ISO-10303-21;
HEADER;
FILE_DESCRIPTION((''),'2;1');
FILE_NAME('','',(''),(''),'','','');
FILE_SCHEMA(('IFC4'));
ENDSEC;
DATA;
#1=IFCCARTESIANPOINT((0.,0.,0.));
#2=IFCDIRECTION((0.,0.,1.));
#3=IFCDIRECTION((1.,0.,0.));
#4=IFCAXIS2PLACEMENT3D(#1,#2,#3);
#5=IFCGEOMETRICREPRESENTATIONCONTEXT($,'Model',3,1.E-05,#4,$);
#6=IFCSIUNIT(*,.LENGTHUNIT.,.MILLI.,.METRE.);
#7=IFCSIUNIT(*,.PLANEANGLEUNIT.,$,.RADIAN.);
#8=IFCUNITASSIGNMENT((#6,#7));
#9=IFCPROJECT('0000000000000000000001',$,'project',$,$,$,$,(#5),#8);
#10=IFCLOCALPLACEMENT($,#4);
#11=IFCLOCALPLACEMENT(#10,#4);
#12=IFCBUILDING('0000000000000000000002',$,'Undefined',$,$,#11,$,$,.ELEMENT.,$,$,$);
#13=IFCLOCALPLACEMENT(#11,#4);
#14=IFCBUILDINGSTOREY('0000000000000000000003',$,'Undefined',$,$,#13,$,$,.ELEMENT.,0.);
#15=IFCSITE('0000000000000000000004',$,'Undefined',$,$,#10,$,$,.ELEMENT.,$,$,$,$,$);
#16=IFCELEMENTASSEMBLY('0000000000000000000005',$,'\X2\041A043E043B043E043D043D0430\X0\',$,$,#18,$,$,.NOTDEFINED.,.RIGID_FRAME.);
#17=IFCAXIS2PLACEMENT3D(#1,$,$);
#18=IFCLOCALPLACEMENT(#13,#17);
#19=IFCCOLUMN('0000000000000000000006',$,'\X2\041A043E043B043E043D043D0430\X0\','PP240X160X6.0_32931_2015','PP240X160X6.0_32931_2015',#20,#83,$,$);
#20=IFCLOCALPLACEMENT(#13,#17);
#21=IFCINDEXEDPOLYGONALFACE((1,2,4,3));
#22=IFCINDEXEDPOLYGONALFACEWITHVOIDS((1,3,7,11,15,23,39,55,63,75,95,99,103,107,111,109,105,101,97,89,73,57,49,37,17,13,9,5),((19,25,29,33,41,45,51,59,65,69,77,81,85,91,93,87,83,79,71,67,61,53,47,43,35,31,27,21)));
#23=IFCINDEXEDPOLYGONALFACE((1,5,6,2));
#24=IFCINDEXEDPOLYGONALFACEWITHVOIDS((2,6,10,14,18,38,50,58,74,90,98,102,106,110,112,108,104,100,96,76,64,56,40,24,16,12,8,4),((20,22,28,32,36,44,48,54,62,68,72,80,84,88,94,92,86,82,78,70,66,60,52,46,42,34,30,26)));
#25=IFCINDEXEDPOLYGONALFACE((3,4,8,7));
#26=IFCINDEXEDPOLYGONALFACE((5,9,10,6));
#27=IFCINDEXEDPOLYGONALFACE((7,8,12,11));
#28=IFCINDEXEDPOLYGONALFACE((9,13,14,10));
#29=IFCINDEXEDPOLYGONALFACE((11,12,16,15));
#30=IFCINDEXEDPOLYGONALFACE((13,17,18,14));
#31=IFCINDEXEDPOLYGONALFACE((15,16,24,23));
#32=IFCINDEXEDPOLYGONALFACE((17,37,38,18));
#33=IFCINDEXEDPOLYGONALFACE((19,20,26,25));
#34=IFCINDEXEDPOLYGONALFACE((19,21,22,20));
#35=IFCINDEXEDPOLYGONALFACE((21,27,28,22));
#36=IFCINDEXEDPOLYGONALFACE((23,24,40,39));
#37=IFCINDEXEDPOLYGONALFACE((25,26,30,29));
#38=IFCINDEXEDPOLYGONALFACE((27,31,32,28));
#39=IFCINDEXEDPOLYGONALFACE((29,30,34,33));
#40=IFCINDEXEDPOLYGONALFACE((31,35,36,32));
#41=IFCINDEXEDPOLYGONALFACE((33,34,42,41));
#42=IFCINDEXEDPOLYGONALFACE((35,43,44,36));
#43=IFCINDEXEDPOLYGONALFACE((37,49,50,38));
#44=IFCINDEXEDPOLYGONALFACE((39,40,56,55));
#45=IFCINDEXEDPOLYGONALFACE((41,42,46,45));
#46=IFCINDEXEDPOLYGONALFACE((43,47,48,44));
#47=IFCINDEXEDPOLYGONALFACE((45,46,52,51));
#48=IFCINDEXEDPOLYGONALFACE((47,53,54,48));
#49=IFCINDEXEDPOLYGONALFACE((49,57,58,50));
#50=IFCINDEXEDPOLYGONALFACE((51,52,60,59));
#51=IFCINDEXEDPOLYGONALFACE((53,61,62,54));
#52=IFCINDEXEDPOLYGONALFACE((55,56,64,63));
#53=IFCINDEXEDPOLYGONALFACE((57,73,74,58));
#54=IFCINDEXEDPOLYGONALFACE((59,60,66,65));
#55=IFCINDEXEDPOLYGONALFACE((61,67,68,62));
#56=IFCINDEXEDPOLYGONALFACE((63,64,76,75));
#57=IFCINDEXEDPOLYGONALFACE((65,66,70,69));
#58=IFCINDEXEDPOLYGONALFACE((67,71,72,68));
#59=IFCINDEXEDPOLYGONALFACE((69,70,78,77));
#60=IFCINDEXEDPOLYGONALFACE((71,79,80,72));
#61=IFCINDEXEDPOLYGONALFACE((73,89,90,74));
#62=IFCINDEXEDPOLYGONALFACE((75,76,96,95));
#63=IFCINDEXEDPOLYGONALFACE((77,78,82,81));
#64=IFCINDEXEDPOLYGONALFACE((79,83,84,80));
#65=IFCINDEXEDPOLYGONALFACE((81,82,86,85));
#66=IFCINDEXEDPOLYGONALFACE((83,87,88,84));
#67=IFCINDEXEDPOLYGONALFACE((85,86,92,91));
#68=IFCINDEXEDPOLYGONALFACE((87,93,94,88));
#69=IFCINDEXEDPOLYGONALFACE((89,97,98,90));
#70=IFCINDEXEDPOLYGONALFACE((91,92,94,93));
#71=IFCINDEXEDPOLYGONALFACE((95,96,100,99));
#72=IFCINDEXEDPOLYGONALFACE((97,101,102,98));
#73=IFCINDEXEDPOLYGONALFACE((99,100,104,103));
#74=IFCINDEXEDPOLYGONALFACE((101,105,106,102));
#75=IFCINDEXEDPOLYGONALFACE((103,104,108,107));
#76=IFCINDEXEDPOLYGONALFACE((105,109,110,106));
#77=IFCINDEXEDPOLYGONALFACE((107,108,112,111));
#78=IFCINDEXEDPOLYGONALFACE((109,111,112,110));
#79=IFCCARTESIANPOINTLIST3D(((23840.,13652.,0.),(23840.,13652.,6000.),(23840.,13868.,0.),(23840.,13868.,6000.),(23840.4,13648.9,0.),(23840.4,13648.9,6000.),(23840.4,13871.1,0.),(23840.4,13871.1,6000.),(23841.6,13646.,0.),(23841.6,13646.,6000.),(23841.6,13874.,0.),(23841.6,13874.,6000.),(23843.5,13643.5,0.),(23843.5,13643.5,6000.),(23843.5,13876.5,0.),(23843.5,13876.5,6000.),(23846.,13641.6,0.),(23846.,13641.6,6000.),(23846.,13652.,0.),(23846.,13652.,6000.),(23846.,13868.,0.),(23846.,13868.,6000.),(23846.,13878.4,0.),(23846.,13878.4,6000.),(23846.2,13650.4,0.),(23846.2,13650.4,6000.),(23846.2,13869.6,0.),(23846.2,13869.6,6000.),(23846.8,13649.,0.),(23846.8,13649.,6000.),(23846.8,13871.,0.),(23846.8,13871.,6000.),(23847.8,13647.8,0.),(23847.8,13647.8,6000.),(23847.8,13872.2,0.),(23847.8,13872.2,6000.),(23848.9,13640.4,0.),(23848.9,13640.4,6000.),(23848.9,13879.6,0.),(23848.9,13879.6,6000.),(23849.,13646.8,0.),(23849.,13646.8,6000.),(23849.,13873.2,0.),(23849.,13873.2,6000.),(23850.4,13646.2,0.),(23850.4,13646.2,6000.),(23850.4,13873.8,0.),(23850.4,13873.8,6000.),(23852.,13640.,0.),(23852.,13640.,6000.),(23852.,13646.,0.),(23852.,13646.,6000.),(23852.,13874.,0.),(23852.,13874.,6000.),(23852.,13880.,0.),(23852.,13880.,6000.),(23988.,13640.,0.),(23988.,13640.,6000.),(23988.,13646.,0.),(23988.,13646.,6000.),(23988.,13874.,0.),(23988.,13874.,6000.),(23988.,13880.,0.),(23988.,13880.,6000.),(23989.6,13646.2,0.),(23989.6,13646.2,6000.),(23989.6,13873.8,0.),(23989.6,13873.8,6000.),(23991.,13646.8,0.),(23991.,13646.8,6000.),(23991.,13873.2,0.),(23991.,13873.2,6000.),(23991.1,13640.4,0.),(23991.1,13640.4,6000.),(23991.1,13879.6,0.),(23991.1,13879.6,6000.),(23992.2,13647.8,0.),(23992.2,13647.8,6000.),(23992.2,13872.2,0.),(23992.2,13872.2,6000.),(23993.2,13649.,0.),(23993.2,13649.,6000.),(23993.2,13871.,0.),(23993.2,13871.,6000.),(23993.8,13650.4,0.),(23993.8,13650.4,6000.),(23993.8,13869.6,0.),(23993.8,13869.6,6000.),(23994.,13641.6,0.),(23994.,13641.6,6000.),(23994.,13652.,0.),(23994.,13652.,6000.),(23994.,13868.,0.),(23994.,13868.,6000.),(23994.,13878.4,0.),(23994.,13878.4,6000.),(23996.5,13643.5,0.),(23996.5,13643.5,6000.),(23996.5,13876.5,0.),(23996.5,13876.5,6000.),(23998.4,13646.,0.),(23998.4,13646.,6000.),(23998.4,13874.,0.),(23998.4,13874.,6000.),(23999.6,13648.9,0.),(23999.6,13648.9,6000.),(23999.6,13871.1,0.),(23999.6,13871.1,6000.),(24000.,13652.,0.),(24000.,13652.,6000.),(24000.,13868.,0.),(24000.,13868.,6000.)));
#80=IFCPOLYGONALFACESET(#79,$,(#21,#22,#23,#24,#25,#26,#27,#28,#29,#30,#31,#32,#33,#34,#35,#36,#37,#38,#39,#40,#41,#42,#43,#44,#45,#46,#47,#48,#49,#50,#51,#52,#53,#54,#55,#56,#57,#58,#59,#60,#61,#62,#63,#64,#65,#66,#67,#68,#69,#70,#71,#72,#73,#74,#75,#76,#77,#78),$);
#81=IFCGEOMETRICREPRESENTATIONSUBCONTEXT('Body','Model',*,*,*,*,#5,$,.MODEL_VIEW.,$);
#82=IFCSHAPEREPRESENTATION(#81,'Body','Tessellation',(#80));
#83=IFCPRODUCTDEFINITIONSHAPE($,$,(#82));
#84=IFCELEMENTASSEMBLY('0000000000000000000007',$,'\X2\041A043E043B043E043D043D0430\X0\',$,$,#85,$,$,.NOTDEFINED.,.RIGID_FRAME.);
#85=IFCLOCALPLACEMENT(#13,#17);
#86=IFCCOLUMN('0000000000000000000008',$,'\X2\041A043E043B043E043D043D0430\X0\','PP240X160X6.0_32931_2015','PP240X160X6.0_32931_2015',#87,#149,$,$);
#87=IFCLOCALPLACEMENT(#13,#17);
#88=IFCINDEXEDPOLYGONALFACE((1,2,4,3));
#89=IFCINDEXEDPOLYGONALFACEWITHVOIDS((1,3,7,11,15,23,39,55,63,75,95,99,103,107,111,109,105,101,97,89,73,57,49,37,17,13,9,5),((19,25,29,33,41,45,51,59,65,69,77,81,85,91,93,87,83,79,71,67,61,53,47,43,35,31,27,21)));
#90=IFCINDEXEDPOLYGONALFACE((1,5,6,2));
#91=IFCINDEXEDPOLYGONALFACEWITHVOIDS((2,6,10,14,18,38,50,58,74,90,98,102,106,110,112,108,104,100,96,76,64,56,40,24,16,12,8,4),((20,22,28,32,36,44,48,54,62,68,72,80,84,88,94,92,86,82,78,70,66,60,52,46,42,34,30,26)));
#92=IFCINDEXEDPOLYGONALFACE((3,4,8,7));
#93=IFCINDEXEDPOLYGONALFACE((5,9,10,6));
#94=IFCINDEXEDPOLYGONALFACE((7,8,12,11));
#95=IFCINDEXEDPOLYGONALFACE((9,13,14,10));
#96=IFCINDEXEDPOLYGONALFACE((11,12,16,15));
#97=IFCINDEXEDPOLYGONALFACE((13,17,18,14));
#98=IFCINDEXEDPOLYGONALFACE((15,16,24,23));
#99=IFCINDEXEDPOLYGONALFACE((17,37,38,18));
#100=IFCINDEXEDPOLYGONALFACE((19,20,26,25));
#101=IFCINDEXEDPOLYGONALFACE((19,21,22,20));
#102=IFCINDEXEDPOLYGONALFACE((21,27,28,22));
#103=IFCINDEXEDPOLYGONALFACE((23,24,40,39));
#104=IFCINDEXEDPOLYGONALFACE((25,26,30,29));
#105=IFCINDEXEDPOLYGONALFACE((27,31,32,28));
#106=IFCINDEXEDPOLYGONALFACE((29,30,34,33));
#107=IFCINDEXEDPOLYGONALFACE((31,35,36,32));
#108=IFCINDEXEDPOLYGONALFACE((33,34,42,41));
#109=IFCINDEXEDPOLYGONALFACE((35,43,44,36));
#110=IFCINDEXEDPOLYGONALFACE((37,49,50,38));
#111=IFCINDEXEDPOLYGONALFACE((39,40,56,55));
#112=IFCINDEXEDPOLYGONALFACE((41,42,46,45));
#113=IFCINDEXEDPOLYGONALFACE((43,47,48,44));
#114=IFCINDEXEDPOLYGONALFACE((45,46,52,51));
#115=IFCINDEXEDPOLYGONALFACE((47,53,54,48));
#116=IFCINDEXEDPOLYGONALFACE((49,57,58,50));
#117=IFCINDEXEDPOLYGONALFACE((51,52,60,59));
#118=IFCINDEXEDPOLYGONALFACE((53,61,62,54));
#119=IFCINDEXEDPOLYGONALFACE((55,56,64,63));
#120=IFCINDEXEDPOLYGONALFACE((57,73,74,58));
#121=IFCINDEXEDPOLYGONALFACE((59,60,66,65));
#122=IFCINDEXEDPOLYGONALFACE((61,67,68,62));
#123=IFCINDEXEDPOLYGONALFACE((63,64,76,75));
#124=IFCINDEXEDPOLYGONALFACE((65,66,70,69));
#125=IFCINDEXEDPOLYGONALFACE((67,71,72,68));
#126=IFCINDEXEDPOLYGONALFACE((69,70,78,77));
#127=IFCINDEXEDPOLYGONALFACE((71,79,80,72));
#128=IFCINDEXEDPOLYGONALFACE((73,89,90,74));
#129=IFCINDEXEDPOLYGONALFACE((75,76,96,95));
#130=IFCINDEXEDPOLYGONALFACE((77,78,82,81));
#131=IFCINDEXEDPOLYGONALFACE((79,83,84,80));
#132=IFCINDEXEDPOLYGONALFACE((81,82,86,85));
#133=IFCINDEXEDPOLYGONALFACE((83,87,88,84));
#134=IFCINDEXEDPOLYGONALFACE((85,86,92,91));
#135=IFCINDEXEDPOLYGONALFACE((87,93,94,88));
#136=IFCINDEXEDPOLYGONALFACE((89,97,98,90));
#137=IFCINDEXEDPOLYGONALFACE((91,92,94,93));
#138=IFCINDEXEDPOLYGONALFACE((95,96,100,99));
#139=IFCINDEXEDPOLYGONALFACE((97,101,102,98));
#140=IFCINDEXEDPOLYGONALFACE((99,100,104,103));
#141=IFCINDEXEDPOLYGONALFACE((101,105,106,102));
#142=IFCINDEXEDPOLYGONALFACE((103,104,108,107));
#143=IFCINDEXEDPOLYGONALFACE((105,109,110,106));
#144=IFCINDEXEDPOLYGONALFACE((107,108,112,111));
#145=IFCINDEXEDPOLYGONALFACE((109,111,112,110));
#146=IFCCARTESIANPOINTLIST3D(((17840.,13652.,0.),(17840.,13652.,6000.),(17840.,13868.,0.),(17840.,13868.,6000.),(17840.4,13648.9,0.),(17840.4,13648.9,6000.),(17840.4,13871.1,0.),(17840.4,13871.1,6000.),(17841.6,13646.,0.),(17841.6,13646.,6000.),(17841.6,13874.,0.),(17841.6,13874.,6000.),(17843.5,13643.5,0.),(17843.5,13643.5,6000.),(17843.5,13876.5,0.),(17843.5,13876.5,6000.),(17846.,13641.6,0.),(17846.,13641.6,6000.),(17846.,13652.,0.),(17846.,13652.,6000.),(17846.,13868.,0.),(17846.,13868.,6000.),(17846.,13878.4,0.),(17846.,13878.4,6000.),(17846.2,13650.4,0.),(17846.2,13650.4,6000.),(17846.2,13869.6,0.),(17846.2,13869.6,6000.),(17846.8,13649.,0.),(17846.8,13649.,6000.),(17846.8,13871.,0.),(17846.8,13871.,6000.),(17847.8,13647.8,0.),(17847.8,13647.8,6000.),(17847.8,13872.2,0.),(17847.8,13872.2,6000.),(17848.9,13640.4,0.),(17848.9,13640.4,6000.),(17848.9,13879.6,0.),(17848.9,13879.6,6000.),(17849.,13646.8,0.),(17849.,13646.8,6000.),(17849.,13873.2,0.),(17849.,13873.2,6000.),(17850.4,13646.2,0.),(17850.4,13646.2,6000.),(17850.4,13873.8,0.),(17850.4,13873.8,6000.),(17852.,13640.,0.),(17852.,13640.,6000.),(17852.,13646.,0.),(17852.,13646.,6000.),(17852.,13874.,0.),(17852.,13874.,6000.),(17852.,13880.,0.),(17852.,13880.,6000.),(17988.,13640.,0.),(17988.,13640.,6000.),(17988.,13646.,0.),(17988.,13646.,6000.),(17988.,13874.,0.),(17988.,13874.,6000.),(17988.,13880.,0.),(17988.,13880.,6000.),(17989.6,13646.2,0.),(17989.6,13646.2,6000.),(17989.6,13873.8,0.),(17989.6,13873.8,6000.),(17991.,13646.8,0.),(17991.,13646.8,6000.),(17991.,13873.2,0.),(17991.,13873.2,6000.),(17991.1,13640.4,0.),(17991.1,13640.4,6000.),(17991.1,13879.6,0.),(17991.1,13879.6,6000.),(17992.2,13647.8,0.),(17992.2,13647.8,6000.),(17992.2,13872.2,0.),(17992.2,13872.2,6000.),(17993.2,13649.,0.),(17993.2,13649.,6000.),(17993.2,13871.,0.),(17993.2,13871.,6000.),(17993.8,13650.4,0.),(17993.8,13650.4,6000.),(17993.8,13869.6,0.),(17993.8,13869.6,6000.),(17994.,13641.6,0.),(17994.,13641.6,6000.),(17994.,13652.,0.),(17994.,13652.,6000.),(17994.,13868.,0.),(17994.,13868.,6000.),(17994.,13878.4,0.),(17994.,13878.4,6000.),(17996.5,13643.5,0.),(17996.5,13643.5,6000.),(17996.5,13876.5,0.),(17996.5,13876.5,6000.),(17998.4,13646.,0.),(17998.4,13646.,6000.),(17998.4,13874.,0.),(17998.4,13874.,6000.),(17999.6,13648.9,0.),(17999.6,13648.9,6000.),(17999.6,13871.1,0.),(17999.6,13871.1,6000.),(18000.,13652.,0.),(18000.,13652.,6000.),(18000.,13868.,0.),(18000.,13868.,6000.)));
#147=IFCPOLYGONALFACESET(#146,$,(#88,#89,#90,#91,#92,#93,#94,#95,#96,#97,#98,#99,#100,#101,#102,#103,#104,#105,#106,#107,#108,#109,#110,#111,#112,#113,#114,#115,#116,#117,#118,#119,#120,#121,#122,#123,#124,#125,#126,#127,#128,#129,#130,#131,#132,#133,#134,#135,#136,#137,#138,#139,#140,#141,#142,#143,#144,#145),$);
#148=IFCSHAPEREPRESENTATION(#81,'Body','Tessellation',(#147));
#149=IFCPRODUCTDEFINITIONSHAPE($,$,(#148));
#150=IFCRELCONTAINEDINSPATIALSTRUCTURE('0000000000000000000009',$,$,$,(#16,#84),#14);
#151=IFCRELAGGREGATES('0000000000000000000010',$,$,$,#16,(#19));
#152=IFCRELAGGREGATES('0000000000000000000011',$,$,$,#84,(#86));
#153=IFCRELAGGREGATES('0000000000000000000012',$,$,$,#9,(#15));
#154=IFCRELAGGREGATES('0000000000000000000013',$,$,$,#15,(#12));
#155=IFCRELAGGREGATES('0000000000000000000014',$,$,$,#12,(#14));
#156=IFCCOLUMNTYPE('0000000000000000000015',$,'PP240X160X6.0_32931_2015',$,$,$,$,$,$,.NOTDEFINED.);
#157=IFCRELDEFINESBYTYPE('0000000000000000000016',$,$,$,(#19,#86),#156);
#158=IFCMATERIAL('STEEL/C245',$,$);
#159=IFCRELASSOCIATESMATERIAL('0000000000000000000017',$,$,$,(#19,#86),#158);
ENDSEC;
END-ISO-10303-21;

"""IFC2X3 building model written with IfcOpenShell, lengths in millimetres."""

from ifc_helpers import new_model, si_unit, frame, origin_with_axes, origin_2d_with_axis, place, context, subcontext, project, spatial, hollow_rectangle, extrude, material, type_object, element, aggregate, save


model = new_model("IFC2X3")

# Units and contexts
model_context = context("Model", 3, precision=1e-05, world=origin_with_axes())
body_context = subcontext(model_context, "Body", "Model", "MODEL_VIEW")
ifc_project = project(units=[si_unit("LENGTHUNIT", "METRE", prefix="MILLI"), si_unit("PLANEANGLEUNIT", "RADIAN")], contexts=[model_context])

# Site, building, storey
site_placement = place(None, origin_with_axes())
site = spatial("IfcSite", under=ifc_project, at=site_placement, Name="Undefined", CompositionType="ELEMENT")
building_placement = place(site_placement, origin_with_axes())
building = spatial("IfcBuilding", under=site, at=building_placement, Name="Undefined", CompositionType="ELEMENT")
storey_placement = place(building_placement, origin_with_axes())
storey = spatial("IfcBuildingStorey", under=building, at=storey_placement, Name="Undefined", CompositionType="ELEMENT", Elevation=0.0)

# Element assemblies, columns
assembly_1_placement = place(storey_placement, origin_with_axes())
assembly_1 = element("IfcElementAssembly", 1, at=assembly_1_placement, inside=storey, Name="Колонна", AssemblyPlace="NOTDEFINED", PredefinedType="RIGID_FRAME")
ifc_material = material(Name="STEEL/C245")
column_type_1 = type_object("IfcColumnType", Name="PP240X160X6.0_32931_2015", PredefinedType="NOTDEFINED")
column_1_placement = place(assembly_1_placement, frame((23920.0, 13760.0, 0.0), z_axis=(0.0, 0.0, 1.0), x_axis=(0.0, 1.0, 0.0)))
column_1 = element("IfcColumn", 2, at=column_1_placement, type_object=column_type_1, material=ifc_material, Name="Колонна", Description="PP240X160X6.0_32931_2015", ObjectType="PP240X160X6.0_32931_2015", context=body_context, shape_type="SweptSolid", body=[
    extrude(hollow_rectangle(XDim=160.0, YDim=240.0, WallThickness=6.0, InnerFilletRadius=6.0, OuterFilletRadius=12.0, at=origin_2d_with_axis()), frame((0.0, 0.0, 6000.0), z_axis=(0.0, 0.0, -1.0), x_axis=(0.0, 1.0, 0.0)), (0.0, 0.0, 1.0), 6000.0),
])
aggregate(assembly_1, [column_1])
assembly_2_placement = place(storey_placement, origin_with_axes())
assembly_2 = element("IfcElementAssembly", 3, at=assembly_2_placement, inside=storey, Name="Колонна", AssemblyPlace="NOTDEFINED", PredefinedType="RIGID_FRAME")
column_2_placement = place(assembly_2_placement, frame((17920.0, 13760.0, 0.0), z_axis=(0.0, 0.0, 1.0), x_axis=(0.0, 1.0, 0.0)))
column_2 = element("IfcColumn", 4, at=column_2_placement, type_object=column_type_1, material=ifc_material, Name="Колонна", Description="PP240X160X6.0_32931_2015", ObjectType="PP240X160X6.0_32931_2015", context=body_context, shape_type="SweptSolid", body=[
    extrude(hollow_rectangle(XDim=160.0, YDim=240.0, WallThickness=6.0, InnerFilletRadius=6.0, OuterFilletRadius=12.0, at=origin_2d_with_axis()), frame((0.0, 0.0, 6000.0), z_axis=(0.0, 0.0, -1.0), x_axis=(0.0, 1.0, 0.0)), (0.0, 0.0, 1.0), 6000.0),
])
aggregate(assembly_2, [column_2])

save(model, "model.ifc")
